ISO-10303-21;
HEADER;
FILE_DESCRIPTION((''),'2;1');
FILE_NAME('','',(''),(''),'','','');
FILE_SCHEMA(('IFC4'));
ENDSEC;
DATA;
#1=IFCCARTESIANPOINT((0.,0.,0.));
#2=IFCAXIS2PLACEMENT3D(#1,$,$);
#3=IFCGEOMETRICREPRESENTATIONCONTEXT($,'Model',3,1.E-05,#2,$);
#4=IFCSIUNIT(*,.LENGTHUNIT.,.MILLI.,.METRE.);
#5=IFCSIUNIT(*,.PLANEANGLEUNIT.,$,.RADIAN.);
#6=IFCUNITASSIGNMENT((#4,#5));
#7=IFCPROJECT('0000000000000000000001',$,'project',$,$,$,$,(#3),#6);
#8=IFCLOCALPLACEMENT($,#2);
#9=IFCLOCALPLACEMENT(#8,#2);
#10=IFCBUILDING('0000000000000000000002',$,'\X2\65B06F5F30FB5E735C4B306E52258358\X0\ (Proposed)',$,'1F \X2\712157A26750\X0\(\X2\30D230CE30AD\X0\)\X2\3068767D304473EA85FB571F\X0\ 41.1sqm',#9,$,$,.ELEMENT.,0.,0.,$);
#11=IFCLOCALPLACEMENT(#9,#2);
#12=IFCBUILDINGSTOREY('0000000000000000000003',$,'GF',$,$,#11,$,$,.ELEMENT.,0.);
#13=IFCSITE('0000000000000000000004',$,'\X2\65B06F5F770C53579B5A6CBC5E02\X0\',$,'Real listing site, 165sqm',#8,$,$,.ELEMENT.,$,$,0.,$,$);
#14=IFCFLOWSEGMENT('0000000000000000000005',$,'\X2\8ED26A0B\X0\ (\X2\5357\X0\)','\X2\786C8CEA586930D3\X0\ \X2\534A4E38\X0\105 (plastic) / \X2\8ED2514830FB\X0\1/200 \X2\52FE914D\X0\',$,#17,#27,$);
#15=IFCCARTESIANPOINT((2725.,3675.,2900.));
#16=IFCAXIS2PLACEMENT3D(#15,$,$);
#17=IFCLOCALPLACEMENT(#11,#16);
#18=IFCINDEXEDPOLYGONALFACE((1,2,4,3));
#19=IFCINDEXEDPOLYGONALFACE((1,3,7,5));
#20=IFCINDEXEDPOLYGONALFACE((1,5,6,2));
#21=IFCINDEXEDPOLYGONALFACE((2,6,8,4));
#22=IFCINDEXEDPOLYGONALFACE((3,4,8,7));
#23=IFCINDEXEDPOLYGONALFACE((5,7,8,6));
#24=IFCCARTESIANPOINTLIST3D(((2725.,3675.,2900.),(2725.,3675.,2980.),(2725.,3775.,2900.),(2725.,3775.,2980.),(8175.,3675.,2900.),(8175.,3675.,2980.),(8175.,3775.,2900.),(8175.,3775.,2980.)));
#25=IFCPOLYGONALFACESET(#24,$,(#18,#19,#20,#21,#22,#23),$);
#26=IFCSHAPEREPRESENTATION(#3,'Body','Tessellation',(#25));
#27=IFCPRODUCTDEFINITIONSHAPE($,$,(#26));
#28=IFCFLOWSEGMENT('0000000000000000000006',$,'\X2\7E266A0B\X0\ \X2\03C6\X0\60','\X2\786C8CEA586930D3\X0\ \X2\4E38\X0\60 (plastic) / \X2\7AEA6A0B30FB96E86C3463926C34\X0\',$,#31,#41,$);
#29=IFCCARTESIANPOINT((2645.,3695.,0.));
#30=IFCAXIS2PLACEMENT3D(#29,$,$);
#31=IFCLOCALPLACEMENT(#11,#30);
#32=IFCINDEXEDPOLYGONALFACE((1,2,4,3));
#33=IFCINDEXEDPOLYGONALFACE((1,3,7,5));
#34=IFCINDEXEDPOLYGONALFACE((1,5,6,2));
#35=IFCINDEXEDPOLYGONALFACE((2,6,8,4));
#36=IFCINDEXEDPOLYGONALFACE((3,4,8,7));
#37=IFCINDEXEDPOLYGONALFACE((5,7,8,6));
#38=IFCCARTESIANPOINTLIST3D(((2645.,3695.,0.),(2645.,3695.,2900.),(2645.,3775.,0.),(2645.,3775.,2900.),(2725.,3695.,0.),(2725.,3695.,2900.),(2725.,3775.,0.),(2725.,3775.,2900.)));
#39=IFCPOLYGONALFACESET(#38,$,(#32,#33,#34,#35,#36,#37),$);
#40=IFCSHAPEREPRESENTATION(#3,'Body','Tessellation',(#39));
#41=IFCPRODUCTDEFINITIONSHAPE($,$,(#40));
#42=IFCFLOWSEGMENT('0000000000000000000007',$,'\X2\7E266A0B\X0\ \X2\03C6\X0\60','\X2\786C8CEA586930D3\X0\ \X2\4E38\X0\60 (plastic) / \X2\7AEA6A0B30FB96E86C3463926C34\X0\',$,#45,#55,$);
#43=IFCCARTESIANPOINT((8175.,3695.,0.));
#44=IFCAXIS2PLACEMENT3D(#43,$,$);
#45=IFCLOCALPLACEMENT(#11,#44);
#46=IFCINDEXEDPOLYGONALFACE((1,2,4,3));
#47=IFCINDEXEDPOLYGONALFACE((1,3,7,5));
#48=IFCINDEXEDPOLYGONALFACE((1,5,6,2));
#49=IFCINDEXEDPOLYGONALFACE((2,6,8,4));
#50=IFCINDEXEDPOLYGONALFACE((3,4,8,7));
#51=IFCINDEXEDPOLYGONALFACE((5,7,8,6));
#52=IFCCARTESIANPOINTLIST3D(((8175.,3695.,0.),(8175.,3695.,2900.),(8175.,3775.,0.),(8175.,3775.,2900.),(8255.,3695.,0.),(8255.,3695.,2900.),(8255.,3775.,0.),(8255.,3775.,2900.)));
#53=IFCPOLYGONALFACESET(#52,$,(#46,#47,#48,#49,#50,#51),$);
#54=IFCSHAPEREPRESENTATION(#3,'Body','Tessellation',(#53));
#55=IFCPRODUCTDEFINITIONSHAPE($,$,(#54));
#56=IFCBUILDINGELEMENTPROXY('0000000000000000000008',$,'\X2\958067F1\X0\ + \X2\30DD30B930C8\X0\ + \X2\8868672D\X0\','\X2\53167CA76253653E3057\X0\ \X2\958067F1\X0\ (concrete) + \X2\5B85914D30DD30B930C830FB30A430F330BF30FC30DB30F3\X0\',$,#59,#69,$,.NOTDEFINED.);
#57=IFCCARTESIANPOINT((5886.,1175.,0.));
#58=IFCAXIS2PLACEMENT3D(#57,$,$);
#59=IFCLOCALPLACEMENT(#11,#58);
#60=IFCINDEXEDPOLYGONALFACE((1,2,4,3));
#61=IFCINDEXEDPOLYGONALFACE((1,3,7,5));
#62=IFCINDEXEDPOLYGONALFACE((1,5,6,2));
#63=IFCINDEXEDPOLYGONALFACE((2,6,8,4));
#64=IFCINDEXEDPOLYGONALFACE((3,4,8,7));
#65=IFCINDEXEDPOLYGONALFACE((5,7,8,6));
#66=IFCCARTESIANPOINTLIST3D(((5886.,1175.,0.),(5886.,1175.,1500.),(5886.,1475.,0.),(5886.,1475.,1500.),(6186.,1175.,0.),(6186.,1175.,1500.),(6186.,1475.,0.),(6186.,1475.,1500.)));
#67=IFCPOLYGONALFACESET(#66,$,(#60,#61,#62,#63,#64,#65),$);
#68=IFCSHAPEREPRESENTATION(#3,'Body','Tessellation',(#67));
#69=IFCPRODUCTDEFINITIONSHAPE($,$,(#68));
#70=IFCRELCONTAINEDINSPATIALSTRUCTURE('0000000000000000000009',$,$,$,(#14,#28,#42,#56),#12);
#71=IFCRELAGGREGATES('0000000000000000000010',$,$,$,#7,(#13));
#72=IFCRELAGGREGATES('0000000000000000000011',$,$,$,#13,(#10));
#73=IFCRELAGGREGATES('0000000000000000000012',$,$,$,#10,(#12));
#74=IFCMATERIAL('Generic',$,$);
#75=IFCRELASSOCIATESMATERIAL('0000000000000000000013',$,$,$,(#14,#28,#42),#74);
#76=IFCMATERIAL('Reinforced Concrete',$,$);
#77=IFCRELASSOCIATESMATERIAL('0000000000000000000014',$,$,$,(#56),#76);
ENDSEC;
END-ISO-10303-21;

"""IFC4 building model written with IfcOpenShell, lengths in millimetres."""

from ifc_helpers import new_model, si_unit, frame, frame_2d, origin, place, context, project, spatial, rectangle, extrude, material, element, save


model = new_model("IFC4")

# Units and contexts
model_context = context("Model", 3, precision=1e-05, world=origin())
ifc_project = project(units=[si_unit("LENGTHUNIT", "METRE", prefix="MILLI"), si_unit("PLANEANGLEUNIT", "RADIAN")], contexts=[model_context])

# Site, building, storey
site_placement = place(None, origin())
site = spatial("IfcSite", under=ifc_project, at=site_placement, Name="新潟県南魚沼市", ObjectType="Real listing site, 165sqm", CompositionType="ELEMENT", RefElevation=0.0)
building_placement = place(site_placement, origin())
building = spatial("IfcBuilding", under=site, at=building_placement, Name="新潟・平屋の別荘 (Proposed)", ObjectType="1F 無垢材(ヒノキ)と白い珪藻土 41.1sqm", CompositionType="ELEMENT", ElevationOfRefHeight=0.0, ElevationOfTerrain=0.0)
storey_placement = place(building_placement, origin())
storey = spatial("IfcBuildingStorey", under=building, at=storey_placement, Name="GF", CompositionType="ELEMENT", Elevation=0.0)

# Shared definitions
ifc_material_1 = material(Name="Reinforced Concrete")

# Flow segments
ifc_material_2 = material(Name="Generic")
flow_segment_1_placement = place(storey_placement, frame((2725.0, 3675.0, 2900.0)))
element("IfcFlowSegment", 1, at=flow_segment_1_placement, inside=storey, material=ifc_material_2, Name="軒樋 (南)", Description="硬質塩ビ 半丸105 (plastic) / 軒先・1/200 勾配", context=model_context, shape_type="SweptSolid", body=[
    extrude(rectangle(XDim=5450.0, YDim=100.0, at=frame_2d((2725.0, 50.0))), frame((2725.0, 3675.0, 2900.0)), (0.0, 0.0, 1.0), 80.0),
])
flow_segment_2_placement = place(storey_placement, frame((2645.0, 3695.0, 0.0)))
element("IfcFlowSegment", 2, at=flow_segment_2_placement, inside=storey, material=ifc_material_2, Name="縦樋 φ60", Description="硬質塩ビ 丸60 (plastic) / 竪樋・雨水排水", context=model_context, shape_type="SweptSolid", body=[
    extrude(rectangle(XDim=80.0, YDim=80.0, at=frame_2d((40.0, 40.0))), frame((2645.0, 3695.0, 0.0)), (0.0, 0.0, 1.0), 2900.0),
])
flow_segment_3_placement = place(storey_placement, frame((8175.0, 3695.0, 0.0)))
element("IfcFlowSegment", 3, at=flow_segment_3_placement, inside=storey, material=ifc_material_2, Name="縦樋 φ60", Description="硬質塩ビ 丸60 (plastic) / 竪樋・雨水排水", context=model_context, shape_type="SweptSolid", body=[
    extrude(rectangle(XDim=80.0, YDim=80.0, at=frame_2d((40.0, 40.0))), frame((8175.0, 3695.0, 0.0)), (0.0, 0.0, 1.0), 2900.0),
])

# Building element proxy
proxy_placement = place(storey_placement, frame((5886.0, 1175.0, 0.0)))
element("IfcBuildingElementProxy", 4, at=proxy_placement, inside=storey, material=ifc_material_1, Name="門柱 + ポスト + 表札", Description="化粧打放し 門柱 (concrete) + 宅配ポスト・インターホン", PredefinedType="NOTDEFINED", context=model_context, shape_type="SweptSolid", body=[
    extrude(rectangle(XDim=300.0, YDim=300.0, at=frame_2d((150.0, 150.0))), frame((5886.0, 1175.0, 0.0)), (0.0, 0.0, 1.0), 1500.0),
])

save(model, "model.ifc")
